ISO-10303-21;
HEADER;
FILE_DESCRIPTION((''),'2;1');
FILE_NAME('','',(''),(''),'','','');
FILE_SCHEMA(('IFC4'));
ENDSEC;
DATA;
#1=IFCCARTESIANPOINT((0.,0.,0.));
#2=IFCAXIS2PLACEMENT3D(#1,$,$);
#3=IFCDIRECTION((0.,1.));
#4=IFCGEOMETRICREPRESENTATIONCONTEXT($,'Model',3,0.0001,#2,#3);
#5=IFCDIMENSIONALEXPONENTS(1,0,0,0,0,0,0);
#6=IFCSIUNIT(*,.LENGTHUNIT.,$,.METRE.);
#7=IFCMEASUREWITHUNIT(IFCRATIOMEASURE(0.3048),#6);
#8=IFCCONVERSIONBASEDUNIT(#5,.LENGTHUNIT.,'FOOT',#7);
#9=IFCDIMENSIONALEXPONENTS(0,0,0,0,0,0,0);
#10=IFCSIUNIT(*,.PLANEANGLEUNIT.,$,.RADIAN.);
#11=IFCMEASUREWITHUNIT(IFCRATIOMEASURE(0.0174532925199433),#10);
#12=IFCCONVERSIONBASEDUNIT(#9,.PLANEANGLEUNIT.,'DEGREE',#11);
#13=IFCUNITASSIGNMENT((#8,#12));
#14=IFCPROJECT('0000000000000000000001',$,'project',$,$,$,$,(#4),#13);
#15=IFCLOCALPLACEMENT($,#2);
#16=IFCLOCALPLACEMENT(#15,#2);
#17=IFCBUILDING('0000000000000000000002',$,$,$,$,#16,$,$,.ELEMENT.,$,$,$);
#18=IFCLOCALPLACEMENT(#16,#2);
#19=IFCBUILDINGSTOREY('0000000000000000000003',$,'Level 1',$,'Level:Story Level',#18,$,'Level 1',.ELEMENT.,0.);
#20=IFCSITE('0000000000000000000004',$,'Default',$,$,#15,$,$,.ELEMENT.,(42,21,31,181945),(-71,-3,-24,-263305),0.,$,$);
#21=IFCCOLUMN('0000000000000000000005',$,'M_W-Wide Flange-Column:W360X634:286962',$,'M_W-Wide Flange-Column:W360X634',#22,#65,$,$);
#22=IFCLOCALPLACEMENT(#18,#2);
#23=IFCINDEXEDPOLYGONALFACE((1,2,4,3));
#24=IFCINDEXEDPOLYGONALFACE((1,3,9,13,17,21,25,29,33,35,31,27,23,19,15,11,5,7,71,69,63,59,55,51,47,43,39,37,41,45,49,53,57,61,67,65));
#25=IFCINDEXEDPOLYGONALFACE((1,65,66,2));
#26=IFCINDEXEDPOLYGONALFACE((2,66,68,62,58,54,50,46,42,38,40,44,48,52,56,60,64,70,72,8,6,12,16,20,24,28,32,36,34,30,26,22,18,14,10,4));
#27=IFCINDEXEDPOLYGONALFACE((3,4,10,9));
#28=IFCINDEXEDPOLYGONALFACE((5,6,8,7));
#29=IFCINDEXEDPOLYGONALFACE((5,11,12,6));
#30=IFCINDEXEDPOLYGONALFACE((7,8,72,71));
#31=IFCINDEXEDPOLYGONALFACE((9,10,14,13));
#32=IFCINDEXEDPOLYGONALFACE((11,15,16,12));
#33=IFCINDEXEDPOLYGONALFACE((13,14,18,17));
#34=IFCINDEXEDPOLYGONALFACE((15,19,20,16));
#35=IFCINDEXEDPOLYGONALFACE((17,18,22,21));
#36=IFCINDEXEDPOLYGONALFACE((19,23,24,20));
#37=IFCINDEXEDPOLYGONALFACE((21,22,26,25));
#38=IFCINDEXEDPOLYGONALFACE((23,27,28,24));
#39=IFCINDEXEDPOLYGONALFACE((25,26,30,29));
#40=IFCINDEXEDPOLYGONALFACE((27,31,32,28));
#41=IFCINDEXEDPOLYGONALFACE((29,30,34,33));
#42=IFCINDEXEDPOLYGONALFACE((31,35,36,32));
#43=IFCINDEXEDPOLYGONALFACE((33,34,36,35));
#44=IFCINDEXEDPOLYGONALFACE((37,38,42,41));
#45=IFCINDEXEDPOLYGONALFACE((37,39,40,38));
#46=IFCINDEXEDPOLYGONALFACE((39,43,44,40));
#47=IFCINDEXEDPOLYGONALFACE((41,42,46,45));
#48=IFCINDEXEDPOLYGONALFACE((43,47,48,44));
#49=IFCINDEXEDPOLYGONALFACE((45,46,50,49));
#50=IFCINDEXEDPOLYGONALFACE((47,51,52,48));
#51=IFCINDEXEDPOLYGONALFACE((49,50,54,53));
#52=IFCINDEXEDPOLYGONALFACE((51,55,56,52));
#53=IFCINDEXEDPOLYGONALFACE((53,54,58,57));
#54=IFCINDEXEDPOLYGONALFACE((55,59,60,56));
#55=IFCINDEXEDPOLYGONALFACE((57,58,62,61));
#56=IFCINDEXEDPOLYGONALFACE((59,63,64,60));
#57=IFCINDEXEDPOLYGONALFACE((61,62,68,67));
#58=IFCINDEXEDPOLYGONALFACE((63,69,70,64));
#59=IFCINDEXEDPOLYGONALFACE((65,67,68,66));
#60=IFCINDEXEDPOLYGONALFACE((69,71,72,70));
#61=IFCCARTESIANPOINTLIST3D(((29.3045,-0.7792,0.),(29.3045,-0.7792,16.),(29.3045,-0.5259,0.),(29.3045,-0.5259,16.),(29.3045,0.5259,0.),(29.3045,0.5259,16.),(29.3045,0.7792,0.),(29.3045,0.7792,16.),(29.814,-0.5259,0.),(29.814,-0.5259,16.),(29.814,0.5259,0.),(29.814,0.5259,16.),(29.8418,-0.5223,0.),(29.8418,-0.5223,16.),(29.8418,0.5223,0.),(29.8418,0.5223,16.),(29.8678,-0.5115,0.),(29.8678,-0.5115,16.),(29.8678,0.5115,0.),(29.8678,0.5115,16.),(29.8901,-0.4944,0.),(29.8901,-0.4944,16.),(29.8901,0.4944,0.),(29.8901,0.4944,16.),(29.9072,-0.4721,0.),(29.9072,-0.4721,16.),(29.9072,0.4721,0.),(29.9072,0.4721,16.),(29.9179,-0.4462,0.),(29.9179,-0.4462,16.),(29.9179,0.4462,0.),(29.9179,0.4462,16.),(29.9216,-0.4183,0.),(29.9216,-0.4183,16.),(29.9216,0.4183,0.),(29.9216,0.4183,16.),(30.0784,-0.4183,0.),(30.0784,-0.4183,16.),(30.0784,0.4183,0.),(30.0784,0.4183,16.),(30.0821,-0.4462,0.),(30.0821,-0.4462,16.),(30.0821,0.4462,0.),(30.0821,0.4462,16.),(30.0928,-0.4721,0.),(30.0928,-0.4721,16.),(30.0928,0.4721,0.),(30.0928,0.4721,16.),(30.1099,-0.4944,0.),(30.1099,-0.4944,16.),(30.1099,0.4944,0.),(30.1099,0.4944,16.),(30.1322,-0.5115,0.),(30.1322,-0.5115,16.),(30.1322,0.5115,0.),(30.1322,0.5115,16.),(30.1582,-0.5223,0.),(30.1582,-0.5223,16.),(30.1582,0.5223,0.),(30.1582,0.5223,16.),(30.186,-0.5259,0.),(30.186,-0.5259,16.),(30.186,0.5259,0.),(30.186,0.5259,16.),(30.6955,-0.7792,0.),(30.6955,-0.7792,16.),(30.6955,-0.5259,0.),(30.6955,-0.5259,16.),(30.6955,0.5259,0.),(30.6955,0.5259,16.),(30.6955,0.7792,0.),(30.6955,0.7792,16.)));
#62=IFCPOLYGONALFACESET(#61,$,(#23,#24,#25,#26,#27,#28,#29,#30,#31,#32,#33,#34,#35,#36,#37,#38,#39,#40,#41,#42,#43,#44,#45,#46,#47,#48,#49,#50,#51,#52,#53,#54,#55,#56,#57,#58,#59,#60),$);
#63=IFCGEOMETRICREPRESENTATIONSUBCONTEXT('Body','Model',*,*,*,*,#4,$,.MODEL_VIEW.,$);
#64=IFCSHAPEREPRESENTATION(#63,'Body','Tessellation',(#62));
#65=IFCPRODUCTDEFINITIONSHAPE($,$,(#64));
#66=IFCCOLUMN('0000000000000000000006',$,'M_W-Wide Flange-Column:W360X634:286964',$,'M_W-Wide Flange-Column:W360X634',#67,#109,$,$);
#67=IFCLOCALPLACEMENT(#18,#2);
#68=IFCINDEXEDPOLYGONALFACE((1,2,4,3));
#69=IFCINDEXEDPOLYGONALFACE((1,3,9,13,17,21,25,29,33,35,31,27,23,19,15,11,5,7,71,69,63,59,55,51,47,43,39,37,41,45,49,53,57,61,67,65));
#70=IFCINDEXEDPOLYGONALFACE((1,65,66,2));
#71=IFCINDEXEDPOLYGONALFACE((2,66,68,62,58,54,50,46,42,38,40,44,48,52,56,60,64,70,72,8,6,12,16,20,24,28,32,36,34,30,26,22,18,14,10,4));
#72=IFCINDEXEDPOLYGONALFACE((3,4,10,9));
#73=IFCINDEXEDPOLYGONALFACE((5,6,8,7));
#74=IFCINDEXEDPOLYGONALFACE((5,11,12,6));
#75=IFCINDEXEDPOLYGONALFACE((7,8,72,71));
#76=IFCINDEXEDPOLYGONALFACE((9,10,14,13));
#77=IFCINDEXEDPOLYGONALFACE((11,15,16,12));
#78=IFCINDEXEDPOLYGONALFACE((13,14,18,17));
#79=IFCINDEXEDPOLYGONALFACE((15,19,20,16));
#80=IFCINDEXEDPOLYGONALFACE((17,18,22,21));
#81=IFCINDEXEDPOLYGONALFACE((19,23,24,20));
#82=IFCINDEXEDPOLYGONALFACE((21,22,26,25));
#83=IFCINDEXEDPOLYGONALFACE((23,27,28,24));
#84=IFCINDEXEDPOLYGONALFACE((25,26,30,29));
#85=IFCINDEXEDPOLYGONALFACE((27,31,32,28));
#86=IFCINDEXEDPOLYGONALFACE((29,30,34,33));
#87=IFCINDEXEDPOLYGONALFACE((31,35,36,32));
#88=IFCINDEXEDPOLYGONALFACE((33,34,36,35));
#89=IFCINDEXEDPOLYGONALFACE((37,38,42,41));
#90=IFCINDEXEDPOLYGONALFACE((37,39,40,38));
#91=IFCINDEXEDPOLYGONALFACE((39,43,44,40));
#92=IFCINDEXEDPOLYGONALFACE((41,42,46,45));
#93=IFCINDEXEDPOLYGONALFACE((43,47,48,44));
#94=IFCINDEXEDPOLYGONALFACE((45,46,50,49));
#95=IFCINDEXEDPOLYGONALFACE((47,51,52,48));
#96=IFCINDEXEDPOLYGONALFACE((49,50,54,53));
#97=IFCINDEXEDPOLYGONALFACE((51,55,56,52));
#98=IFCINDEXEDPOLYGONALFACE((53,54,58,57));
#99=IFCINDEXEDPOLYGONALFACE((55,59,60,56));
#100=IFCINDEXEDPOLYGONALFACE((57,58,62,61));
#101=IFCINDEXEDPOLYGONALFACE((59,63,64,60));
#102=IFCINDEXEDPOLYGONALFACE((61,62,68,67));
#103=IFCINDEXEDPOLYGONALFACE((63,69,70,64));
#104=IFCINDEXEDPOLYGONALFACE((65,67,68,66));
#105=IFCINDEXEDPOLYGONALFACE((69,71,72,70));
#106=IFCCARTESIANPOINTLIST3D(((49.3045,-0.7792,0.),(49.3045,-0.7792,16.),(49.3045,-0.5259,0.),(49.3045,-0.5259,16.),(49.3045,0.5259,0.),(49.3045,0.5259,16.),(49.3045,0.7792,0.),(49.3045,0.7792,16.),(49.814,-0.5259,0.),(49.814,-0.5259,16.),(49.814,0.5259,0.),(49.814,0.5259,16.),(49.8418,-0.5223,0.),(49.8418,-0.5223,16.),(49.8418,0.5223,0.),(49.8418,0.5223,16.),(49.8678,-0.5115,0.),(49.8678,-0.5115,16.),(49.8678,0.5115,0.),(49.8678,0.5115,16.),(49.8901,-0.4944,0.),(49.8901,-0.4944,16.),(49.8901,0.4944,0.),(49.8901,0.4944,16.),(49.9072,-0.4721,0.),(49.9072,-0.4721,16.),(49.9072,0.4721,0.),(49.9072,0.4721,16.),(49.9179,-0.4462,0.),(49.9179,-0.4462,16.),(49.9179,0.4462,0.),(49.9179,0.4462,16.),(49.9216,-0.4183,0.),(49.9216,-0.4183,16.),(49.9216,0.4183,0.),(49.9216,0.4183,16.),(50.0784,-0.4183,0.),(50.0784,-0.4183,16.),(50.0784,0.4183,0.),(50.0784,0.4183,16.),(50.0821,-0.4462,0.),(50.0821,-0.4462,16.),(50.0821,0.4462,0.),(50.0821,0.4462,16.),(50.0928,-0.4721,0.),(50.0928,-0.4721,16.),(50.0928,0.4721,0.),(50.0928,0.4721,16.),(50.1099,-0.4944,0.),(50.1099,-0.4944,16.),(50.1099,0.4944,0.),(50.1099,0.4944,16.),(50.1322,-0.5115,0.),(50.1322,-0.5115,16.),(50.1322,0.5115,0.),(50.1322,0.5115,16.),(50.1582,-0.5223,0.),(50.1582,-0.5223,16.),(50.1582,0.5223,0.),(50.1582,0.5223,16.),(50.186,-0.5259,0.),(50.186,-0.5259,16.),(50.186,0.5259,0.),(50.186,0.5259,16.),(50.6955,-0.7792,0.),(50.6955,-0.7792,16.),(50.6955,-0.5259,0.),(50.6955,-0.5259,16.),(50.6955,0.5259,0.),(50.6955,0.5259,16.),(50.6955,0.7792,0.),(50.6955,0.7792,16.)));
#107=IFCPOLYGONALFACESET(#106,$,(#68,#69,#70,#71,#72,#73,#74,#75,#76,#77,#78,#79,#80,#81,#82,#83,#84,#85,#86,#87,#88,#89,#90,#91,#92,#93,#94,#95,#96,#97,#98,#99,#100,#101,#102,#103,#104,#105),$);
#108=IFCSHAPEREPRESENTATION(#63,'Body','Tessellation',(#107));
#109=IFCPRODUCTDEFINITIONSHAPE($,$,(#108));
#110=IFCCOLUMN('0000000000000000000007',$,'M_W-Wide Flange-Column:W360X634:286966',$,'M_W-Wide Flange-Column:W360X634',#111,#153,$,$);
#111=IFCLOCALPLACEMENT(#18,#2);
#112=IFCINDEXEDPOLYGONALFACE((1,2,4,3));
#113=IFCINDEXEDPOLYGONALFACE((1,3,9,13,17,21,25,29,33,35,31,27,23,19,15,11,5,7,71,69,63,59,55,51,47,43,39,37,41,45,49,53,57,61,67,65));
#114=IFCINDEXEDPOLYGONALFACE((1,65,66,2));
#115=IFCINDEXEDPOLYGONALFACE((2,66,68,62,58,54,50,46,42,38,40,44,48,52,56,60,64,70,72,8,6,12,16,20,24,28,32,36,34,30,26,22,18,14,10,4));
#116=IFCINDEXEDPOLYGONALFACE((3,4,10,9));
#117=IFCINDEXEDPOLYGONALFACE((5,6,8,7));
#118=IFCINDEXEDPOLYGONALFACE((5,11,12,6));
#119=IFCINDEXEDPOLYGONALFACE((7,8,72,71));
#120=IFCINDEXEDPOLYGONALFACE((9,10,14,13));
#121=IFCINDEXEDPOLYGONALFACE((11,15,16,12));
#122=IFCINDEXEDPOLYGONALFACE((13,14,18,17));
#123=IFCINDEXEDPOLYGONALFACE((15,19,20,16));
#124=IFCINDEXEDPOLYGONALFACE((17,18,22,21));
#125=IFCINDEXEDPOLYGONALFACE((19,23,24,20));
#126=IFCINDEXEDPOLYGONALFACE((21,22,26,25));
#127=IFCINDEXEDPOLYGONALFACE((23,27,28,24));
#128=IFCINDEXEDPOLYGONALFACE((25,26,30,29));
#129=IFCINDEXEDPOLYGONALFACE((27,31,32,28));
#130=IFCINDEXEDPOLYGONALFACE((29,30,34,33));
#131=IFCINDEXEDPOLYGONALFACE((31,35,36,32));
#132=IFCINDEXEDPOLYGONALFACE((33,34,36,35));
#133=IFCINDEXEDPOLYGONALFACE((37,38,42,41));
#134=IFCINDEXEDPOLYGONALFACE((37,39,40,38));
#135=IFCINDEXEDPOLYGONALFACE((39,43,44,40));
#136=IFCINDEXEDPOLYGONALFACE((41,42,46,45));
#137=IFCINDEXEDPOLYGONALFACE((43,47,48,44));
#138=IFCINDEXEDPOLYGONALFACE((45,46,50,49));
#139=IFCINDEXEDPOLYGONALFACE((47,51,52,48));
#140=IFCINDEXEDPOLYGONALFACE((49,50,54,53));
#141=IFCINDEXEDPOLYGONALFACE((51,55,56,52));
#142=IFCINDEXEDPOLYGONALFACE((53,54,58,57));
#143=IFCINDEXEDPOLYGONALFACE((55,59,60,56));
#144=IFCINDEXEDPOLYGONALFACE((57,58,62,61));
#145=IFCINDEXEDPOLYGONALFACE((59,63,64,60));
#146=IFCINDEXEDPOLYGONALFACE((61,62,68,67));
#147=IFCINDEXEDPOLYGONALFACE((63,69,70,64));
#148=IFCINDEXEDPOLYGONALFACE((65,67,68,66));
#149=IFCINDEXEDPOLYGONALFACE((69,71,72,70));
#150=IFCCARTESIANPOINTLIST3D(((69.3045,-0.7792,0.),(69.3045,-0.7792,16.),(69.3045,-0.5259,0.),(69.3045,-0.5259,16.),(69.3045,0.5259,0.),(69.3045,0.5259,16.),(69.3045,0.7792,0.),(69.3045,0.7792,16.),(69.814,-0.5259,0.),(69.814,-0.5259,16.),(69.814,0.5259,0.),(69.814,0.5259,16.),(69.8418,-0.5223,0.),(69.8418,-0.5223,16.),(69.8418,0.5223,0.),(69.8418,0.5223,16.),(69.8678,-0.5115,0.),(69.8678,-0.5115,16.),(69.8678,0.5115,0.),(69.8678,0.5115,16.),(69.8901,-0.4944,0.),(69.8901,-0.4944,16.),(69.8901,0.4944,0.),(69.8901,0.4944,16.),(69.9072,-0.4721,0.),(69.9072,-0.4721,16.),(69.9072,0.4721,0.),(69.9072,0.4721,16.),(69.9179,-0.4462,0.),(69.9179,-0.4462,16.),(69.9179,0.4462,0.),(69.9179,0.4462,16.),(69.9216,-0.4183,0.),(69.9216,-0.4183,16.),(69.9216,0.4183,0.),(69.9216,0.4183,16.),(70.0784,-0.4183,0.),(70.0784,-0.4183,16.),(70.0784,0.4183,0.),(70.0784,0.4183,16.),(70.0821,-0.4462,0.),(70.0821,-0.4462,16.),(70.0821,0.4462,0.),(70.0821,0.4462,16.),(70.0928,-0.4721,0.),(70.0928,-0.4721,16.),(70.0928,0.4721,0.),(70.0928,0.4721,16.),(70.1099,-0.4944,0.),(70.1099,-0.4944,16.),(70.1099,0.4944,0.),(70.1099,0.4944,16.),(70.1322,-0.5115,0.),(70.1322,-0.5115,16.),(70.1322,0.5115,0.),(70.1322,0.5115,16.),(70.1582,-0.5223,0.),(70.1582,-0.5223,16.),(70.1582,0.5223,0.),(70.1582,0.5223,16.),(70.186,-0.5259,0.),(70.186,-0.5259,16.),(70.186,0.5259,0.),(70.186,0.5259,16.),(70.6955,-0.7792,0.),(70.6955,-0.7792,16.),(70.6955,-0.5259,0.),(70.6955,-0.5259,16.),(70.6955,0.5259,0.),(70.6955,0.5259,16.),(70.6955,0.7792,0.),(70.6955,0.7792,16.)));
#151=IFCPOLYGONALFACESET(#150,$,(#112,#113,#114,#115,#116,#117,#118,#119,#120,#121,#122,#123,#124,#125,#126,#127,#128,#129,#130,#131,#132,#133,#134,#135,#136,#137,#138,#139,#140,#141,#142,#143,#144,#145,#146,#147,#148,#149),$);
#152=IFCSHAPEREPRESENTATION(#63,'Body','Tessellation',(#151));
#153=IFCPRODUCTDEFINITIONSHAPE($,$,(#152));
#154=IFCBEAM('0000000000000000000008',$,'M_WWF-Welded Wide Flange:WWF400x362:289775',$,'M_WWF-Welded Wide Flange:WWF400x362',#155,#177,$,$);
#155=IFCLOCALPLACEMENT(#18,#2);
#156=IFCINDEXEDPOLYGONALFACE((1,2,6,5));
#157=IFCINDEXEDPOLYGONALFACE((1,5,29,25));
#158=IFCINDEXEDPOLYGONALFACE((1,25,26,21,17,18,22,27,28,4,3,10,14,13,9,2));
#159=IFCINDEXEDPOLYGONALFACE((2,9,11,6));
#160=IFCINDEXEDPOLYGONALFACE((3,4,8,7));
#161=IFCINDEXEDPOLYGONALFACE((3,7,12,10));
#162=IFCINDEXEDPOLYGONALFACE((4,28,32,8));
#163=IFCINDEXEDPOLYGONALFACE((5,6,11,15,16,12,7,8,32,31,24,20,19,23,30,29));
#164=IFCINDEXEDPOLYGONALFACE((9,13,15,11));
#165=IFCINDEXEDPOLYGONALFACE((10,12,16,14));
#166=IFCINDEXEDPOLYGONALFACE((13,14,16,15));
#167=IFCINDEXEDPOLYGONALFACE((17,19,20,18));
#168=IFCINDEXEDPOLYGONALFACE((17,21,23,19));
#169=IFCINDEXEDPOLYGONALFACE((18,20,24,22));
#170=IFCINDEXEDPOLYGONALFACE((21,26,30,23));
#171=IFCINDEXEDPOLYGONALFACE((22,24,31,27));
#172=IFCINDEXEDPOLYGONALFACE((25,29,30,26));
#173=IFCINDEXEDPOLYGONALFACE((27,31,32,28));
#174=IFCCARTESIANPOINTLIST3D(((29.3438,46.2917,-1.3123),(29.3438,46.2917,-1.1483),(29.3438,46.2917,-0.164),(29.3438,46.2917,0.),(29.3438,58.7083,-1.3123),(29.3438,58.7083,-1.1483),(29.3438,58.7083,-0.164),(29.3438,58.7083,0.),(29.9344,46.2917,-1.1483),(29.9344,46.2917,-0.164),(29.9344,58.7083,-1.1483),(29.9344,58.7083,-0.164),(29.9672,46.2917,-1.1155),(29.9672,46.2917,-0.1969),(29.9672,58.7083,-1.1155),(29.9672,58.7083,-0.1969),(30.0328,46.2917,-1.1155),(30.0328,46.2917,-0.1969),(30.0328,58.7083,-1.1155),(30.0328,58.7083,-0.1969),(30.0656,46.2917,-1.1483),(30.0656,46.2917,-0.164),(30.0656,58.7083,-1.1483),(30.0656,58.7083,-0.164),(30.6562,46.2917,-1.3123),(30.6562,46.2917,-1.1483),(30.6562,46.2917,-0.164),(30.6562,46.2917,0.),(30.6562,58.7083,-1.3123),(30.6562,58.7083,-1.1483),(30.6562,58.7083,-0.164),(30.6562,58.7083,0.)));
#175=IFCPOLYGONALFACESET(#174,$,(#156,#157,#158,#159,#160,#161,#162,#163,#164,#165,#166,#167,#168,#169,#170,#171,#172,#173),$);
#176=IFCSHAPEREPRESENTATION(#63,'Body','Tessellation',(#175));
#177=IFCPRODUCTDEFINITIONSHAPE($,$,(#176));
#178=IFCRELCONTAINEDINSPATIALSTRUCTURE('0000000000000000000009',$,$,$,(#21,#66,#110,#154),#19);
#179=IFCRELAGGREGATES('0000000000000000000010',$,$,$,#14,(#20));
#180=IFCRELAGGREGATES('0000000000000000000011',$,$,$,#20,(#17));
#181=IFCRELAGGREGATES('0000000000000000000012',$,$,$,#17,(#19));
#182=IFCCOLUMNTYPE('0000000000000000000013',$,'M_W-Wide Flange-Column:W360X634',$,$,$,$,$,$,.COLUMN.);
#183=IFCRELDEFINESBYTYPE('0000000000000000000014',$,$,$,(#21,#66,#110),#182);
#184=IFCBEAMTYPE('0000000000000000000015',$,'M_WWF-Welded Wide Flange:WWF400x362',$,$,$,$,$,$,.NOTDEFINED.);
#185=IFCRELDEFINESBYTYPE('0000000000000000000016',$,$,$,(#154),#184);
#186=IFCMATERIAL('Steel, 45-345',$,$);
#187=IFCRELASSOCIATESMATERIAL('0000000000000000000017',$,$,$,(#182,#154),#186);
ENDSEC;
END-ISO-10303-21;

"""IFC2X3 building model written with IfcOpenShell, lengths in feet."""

from ifc_helpers import new_model, entity, si_unit, converted_unit, direction, frame, frame_2d, origin, place, context, subcontext, project, spatial, polyline, circle_curve, parameter, trimmed, segment, composite_curve, outline, extrude, source, transform, mapped, material, type_object, type_shapes, element, save


model = new_model("IFC2X3")

# Units and contexts
model_context = context("Model", 3, precision=0.0001, world=origin(), true_north=direction((0.0, 1.0)))
body_context = subcontext(model_context, "Body", "Model", "MODEL_VIEW")
ifc_project = project(units=[converted_unit("LENGTHUNIT", "FOOT", entity("IfcRatioMeasure", 0.3048), si_unit("LENGTHUNIT", "METRE"), dimensions=[1, 0, 0, 0, 0, 0, 0]), converted_unit("PLANEANGLEUNIT", "DEGREE", entity("IfcRatioMeasure", 0.0174532925199433), si_unit("PLANEANGLEUNIT", "RADIAN"), dimensions=[0, 0, 0, 0, 0, 0, 0])], contexts=[model_context])

# Site, building, storey
site_placement = place(None, origin())
site = spatial("IfcSite", under=ifc_project, at=site_placement, Name="Default", CompositionType="ELEMENT", RefLatitude=(42, 21, 31, 181945), RefLongitude=(-71, -3, -24, -263305), RefElevation=0.0)
building_placement = place(site_placement, origin())
building = spatial("IfcBuilding", under=site, at=building_placement, CompositionType="ELEMENT")
storey_placement = place(building_placement, origin())
storey = spatial("IfcBuildingStorey", under=building, at=storey_placement, Name="Level 1", ObjectType="Level:Story Level", LongName="Level 1", CompositionType="ELEMENT", Elevation=0.0)

# Columns
ifc_material = material(Name="Steel, 45-345")
column_type = type_object("IfcColumnType", Name="M_W-Wide Flange-Column:W360X634", PredefinedType="COLUMN", material=ifc_material)
shared_shape = source(origin(), body_context, "Body", "SweptSolid", [
    extrude(outline(composite_curve([segment(polyline([(0.5259, -0.6955), (0.7792, -0.6955)]), True, "CONTINUOUS"), segment(polyline([(0.7792, -0.6955), (0.7792, 0.6955)]), True, "CONTINUOUS"), segment(polyline([(0.7792, 0.6955), (0.5259, 0.6955)]), True, "CONTINUOUS"), segment(polyline([(0.5259, 0.6955), (0.5259, 0.186)]), True, "CONTINUOUS"), segment(trimmed(circle_curve(frame_2d((0.4183, 0.186), x_axis=(1.0, 0.0)), 0.1076), [parameter(270.0)], [parameter(0.0)], True, "PARAMETER"), False, "CONTINUOUS"), segment(polyline([(0.4183, 0.0784), (-0.4183, 0.0784)]), True, "CONTINUOUS"), segment(trimmed(circle_curve(frame_2d((-0.4183, 0.186), x_axis=(0.0, -1.0)), 0.1076), [parameter(270.0)], [parameter(0.0)], True, "PARAMETER"), False, "CONTINUOUS"), segment(polyline([(-0.5259, 0.186), (-0.5259, 0.6955)]), True, "CONTINUOUS"), segment(polyline([(-0.5259, 0.6955), (-0.7792, 0.6955)]), True, "CONTINUOUS"), segment(polyline([(-0.7792, 0.6955), (-0.7792, -0.6955)]), True, "CONTINUOUS"), segment(polyline([(-0.7792, -0.6955), (-0.5259, -0.6955)]), True, "CONTINUOUS"), segment(polyline([(-0.5259, -0.6955), (-0.5259, -0.186)]), True, "CONTINUOUS"), segment(trimmed(circle_curve(frame_2d((-0.4183, -0.186), x_axis=(-1.0, 0.0)), 0.1076), [parameter(270.0)], [parameter(0.0)], True, "PARAMETER"), False, "CONTINUOUS"), segment(polyline([(-0.4183, -0.0784), (0.4183, -0.0784)]), True, "CONTINUOUS"), segment(trimmed(circle_curve(frame_2d((0.4183, -0.186), x_axis=(0.0, 1.0)), 0.1076), [parameter(270.0)], [parameter(0.0)], True, "PARAMETER"), False, "CONTINUOUS"), segment(polyline([(0.5259, -0.186), (0.5259, -0.6955)]), True, "CONTINUOUS")], self_intersect=False)), frame((0.0, 0.0, 0.0), z_axis=(0.0, 0.0, 1.0), x_axis=(0.0, -1.0, 0.0)), (0.0, 0.0, 1.0), 16.0),
])
type_shapes(column_type, [shared_shape])
for number, where, name in (
    (1, (30.0, 0.0, 0.0), "M_W-Wide Flange-Column:W360X634:286962"),
    (2, (50.0, 0.0, 0.0), "M_W-Wide Flange-Column:W360X634:286964"),
    (3, (70.0, 0.0, 0.0), "M_W-Wide Flange-Column:W360X634:286966"),
):
    element("IfcColumn", number, at=place(storey_placement, frame(where)), inside=storey, type_object=column_type, Name=name, ObjectType="M_W-Wide Flange-Column:W360X634", context=body_context, shape_type="MappedRepresentation", body=[
        mapped(shared_shape, transform((0.0, 0.0, 0.0), scale=1.0)),
    ])

# Beam
beam_type = type_object("IfcBeamType", Name="M_WWF-Welded Wide Flange:WWF400x362", PredefinedType="NOTDEFINED")
beam_1_placement = place(storey_placement, frame((30.0, 45.0, 0.0), z_axis=(0.0, 0.0, 1.0), x_axis=(0.0, 1.0, 0.0)))
element("IfcBeam", 4, at=beam_1_placement, inside=storey, type_object=beam_type, material=ifc_material, Name="M_WWF-Welded Wide Flange:WWF400x362:289775", ObjectType="M_WWF-Welded Wide Flange:WWF400x362", context=body_context, shape_type="SweptSolid", body=[
    extrude(outline(polyline([(-0.6562, -0.6562), (-0.4921, -0.6562), (-0.4921, -0.0656), (-0.4593, -0.0328), (0.4593, -0.0328), (0.4921, -0.0656), (0.4921, -0.6562), (0.6562, -0.6562), (0.6562, 0.6562), (0.4921, 0.6562), (0.4921, 0.0656), (0.4593, 0.0328), (-0.4593, 0.0328), (-0.4921, 0.0656), (-0.4921, 0.6562), (-0.6562, 0.6562), (-0.6562, -0.6562)])), frame((1.2917, 0.0, -0.6562), z_axis=(1.0, 0.0, 0.0), x_axis=(0.0, 0.0, -1.0)), (0.0, 0.0, 1.0), 12.4167),
])

save(model, "model.ifc")
